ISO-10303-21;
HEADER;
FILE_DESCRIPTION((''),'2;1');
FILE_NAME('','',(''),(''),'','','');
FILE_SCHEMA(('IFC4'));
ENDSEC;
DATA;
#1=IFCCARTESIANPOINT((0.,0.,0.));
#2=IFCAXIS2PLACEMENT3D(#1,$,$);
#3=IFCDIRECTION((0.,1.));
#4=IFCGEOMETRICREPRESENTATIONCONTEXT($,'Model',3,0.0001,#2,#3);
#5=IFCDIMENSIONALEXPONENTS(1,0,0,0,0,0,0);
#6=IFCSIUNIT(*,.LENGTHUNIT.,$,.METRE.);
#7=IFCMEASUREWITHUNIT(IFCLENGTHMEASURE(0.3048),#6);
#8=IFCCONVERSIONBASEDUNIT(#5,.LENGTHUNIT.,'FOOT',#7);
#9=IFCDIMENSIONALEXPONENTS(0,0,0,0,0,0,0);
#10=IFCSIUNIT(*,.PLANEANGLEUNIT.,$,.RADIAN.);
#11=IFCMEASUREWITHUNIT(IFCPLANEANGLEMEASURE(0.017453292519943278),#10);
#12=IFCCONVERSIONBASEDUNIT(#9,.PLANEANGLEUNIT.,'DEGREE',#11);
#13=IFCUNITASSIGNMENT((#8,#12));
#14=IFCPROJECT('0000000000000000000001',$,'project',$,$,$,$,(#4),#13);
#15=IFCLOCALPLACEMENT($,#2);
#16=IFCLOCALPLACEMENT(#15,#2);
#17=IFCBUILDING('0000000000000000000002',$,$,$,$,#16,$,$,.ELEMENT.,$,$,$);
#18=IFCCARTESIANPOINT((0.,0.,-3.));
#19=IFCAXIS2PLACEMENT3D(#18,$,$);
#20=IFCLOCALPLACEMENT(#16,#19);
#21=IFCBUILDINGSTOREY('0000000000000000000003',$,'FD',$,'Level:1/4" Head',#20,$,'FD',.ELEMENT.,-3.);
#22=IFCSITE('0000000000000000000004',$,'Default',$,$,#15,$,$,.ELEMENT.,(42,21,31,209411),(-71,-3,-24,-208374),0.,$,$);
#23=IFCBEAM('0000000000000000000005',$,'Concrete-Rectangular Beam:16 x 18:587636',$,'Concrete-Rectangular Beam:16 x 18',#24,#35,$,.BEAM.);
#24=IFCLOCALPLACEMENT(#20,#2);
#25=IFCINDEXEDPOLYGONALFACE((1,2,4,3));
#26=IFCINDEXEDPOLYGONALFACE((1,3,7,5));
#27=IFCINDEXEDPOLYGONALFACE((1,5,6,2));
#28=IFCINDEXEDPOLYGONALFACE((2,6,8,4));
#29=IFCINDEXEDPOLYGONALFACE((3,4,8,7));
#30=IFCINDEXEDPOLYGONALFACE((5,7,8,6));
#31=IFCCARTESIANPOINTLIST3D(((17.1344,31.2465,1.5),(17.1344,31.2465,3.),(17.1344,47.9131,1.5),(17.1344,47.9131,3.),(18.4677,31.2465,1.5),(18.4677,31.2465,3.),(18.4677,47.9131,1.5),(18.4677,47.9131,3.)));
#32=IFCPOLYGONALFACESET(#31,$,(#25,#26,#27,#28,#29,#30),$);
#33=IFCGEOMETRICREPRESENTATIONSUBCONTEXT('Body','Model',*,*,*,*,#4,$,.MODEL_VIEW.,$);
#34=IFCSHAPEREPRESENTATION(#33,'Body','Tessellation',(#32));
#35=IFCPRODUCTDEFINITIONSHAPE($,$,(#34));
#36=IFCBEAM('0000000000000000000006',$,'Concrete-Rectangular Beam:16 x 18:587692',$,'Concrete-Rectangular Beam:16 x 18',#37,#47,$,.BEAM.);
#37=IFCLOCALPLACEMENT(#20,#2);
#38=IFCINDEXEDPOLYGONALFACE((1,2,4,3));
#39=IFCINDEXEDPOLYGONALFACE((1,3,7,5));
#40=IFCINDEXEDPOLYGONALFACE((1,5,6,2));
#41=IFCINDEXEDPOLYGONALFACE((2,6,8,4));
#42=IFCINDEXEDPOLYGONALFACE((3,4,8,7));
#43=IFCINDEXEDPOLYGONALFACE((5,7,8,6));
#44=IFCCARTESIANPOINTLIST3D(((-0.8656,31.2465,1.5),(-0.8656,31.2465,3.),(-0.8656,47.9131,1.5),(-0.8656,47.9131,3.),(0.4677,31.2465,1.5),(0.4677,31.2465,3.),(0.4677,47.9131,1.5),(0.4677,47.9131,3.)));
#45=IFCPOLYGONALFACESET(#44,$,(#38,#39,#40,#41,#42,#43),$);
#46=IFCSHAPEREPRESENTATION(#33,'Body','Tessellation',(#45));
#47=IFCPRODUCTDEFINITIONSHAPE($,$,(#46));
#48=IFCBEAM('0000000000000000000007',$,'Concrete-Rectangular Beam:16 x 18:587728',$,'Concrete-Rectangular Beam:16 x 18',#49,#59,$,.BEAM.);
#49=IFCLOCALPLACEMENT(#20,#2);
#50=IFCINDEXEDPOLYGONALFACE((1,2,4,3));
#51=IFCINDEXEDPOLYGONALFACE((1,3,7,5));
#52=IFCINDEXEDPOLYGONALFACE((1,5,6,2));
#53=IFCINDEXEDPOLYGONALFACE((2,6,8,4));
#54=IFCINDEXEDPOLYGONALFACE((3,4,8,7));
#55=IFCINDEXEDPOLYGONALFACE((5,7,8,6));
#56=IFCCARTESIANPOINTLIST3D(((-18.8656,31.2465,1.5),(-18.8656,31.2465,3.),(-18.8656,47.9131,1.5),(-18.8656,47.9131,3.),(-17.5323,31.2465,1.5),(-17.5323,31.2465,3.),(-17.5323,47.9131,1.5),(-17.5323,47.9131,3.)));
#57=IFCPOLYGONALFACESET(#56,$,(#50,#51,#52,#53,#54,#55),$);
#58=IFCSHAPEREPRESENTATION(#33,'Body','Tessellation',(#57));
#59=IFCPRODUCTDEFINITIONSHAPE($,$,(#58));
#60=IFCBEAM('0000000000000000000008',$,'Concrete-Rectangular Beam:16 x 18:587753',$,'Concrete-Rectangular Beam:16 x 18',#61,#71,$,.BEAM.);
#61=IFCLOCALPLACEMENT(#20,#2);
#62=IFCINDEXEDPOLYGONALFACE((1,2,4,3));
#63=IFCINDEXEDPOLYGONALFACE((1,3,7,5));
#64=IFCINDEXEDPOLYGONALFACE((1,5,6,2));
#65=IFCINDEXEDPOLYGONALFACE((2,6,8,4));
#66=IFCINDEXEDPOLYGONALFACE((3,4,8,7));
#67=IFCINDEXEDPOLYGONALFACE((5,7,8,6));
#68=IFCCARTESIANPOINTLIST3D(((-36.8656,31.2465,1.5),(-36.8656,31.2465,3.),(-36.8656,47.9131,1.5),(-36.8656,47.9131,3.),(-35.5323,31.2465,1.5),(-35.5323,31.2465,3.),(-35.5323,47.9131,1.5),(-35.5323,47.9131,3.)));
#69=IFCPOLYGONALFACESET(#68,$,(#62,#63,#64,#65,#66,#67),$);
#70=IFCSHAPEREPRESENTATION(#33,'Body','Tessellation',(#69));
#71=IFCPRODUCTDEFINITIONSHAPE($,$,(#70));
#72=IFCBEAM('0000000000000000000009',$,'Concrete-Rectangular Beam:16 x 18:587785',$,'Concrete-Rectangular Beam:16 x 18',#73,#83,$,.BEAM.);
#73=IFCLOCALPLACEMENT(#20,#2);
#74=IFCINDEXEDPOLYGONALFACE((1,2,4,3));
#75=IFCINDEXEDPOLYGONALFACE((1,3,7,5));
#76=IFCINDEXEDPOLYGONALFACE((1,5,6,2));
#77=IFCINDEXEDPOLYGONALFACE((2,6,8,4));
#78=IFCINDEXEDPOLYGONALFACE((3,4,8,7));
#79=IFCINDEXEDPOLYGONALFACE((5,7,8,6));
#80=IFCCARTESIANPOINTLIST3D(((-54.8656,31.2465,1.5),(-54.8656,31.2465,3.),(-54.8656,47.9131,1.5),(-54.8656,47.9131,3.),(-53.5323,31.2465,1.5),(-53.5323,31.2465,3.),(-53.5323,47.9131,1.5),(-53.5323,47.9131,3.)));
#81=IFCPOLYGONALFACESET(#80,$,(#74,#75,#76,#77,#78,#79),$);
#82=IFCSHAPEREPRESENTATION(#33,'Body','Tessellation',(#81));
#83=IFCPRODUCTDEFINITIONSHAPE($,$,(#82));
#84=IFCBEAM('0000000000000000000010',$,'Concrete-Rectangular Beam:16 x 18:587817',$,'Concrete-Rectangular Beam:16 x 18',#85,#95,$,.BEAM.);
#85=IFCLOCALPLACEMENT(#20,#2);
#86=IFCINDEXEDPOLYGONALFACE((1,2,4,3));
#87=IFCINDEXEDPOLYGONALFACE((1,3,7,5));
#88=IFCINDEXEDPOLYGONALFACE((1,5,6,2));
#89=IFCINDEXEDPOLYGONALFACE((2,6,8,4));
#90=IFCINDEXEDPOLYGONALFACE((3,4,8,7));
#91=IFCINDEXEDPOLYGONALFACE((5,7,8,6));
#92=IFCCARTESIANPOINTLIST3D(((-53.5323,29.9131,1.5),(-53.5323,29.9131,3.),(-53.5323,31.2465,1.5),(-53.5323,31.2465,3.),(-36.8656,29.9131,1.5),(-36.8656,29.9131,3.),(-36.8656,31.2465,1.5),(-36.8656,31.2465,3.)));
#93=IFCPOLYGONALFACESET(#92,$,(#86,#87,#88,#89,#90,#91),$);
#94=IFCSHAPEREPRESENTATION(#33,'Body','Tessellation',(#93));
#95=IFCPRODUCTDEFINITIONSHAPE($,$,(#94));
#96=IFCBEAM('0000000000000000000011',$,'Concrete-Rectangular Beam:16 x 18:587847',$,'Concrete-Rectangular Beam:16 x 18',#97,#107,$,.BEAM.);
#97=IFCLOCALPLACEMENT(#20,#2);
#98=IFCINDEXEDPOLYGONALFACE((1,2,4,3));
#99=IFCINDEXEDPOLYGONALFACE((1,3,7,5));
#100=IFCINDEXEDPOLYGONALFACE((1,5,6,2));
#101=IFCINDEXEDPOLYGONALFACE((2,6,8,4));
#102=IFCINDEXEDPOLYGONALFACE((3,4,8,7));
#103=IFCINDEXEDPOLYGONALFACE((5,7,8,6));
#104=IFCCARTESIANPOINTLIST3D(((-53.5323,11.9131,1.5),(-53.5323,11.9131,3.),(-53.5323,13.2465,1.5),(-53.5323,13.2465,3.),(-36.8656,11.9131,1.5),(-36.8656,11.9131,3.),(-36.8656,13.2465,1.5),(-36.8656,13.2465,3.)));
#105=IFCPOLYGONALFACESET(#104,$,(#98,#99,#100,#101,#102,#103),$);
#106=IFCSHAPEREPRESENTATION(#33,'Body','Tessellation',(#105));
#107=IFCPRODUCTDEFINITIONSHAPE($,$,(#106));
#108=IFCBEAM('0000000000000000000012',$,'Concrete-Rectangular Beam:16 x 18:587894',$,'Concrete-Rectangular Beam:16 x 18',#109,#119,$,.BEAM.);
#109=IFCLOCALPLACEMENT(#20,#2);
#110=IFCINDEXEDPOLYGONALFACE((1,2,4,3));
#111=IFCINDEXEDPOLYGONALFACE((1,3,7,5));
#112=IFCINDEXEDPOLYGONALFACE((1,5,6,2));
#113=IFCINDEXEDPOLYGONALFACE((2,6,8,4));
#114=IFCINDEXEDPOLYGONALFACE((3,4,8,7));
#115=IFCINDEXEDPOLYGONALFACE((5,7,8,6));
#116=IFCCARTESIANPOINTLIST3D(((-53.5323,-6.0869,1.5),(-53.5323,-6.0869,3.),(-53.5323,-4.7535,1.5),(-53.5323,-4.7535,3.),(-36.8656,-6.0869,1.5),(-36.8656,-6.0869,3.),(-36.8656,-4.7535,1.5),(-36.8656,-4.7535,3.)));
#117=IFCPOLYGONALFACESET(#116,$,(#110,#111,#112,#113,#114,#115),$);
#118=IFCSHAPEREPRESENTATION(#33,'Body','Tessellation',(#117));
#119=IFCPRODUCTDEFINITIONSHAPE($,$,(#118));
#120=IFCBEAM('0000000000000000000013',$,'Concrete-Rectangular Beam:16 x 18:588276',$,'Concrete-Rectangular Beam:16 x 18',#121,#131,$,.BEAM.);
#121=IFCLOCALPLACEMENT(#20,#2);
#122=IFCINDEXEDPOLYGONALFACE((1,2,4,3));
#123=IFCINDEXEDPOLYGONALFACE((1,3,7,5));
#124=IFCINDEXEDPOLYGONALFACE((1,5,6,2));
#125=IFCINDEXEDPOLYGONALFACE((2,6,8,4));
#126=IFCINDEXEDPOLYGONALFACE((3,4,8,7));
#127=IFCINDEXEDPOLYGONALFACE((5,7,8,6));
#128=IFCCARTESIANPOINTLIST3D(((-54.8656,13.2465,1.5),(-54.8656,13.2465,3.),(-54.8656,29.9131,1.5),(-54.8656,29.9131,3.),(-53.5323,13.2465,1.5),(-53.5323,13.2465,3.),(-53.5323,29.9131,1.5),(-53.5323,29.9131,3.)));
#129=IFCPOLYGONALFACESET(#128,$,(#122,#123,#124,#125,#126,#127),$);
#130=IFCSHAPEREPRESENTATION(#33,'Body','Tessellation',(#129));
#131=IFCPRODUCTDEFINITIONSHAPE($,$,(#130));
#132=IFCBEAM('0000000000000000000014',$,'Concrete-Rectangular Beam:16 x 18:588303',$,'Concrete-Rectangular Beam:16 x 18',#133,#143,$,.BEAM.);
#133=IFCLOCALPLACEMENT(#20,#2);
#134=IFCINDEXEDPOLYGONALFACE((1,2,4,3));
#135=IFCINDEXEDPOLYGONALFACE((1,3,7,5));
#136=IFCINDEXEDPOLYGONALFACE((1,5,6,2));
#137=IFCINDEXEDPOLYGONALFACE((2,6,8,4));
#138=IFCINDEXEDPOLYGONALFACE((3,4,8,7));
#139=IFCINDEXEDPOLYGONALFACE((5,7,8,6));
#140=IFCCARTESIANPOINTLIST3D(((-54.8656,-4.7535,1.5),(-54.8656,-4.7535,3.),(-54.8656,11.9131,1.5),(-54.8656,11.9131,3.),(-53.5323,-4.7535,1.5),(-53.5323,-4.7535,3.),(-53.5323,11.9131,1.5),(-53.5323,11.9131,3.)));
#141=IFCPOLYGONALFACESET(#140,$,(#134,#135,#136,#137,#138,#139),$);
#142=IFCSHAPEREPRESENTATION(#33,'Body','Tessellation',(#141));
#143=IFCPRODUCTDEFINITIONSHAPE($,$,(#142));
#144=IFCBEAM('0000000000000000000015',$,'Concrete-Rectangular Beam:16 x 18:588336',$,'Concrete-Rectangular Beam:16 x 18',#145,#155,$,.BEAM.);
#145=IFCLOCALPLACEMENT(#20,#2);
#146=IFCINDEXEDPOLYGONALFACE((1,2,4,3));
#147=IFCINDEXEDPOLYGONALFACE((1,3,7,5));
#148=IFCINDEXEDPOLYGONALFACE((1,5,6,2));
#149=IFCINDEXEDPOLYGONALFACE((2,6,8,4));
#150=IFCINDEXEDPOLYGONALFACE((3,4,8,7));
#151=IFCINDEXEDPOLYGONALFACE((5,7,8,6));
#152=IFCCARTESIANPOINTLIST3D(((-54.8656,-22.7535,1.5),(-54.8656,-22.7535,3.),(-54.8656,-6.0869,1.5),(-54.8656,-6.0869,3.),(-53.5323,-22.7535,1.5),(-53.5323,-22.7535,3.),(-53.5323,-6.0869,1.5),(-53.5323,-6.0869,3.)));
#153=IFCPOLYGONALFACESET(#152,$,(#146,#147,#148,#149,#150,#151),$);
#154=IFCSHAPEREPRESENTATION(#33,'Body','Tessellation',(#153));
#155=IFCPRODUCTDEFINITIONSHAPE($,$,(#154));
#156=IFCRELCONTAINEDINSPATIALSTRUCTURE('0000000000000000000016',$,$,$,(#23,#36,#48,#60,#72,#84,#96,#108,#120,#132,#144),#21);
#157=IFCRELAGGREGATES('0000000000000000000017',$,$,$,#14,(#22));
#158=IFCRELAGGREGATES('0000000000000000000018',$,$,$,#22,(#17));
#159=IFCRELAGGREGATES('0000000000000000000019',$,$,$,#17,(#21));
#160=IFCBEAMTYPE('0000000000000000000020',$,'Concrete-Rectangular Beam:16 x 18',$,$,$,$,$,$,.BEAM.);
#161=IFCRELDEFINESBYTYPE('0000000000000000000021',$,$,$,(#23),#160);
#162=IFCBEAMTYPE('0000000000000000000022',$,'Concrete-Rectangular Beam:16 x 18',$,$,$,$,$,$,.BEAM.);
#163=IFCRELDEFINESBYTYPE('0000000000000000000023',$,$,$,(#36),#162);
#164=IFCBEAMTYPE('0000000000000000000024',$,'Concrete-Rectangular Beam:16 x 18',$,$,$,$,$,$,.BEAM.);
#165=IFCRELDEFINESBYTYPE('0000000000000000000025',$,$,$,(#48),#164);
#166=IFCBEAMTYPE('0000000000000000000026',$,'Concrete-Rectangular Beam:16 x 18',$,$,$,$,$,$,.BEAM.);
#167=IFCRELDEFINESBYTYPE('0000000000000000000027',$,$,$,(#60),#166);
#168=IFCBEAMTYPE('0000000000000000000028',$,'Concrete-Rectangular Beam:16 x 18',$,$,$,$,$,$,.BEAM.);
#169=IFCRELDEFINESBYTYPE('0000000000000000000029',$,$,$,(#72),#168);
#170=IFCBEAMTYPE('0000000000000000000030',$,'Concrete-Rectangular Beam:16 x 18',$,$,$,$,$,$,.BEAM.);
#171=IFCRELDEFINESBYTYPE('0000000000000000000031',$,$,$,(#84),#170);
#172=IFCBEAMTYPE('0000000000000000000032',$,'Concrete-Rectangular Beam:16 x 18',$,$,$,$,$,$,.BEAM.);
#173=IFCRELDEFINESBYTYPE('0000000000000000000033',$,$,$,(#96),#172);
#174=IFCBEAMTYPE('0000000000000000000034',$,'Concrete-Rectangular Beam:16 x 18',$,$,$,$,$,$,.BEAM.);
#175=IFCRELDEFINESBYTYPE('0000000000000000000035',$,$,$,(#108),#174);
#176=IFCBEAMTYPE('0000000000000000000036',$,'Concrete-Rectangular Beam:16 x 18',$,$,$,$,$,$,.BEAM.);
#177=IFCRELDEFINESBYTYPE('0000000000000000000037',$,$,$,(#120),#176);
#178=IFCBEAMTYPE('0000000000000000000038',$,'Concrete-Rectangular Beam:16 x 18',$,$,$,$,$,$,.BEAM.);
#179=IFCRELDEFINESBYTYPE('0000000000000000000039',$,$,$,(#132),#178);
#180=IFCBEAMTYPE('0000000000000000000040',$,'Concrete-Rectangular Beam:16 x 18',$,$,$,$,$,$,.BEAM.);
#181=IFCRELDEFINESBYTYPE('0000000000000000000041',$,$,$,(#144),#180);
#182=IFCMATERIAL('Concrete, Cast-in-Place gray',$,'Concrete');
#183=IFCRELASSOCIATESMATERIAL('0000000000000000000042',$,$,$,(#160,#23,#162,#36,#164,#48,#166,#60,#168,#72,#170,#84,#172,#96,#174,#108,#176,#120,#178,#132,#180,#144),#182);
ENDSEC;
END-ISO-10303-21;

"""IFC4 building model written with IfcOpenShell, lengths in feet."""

from ifc_helpers import new_model, entity, si_unit, converted_unit, direction, frame, origin, place, context, subcontext, project, spatial, indexed_curve, outline, extrude, source, transform, mapped, material, type_object, type_shapes, element, save


model = new_model("IFC4")

# Units and contexts
model_context = context("Model", 3, precision=0.0001, world=origin(), true_north=direction((0.0, 1.0)))
body_context = subcontext(model_context, "Body", "Model", "MODEL_VIEW")
ifc_project = project(units=[converted_unit("LENGTHUNIT", "FOOT", entity("IfcLengthMeasure", 0.3048), si_unit("LENGTHUNIT", "METRE"), dimensions=[1, 0, 0, 0, 0, 0, 0]), converted_unit("PLANEANGLEUNIT", "DEGREE", entity("IfcPlaneAngleMeasure", 0.017453292519943278), si_unit("PLANEANGLEUNIT", "RADIAN"), dimensions=[0, 0, 0, 0, 0, 0, 0])], contexts=[model_context])

# Site, building, storey
site_placement = place(None, origin())
site = spatial("IfcSite", under=ifc_project, at=site_placement, Name="Default", CompositionType="ELEMENT", RefLatitude=(42, 21, 31, 209411), RefLongitude=(-71, -3, -24, -208374), RefElevation=0.0)
building_placement = place(site_placement, origin())
building = spatial("IfcBuilding", under=site, at=building_placement, CompositionType="ELEMENT")
storey_placement = place(building_placement, frame((0.0, 0.0, -3.0)))
storey = spatial("IfcBuildingStorey", under=building, at=storey_placement, Name="FD", ObjectType="Level:1/4\" Head", LongName="FD", CompositionType="ELEMENT", Elevation=-3.0)

# Shared definitions
ifc_material = material(Name="Concrete, Cast-in-Place gray", Category="Concrete")

# Beams
beam_type_1 = type_object("IfcBeamType", Name="Concrete-Rectangular Beam:16 x 18", PredefinedType="BEAM", material=ifc_material)
shared_shape_1 = source(origin(), body_context, "Body", "SweptSolid", [
    extrude(outline(indexed_curve([(-0.6667, -0.75), (0.6667, -0.75), (0.6667, 0.75), (-0.6667, 0.75), (-0.6667, -0.75)], self_intersect=False)), frame((17.801, 47.9131, -0.75), z_axis=(0.0, -1.0, 0.0), x_axis=(-1.0, 0.0, 0.0)), (0.0, 0.0, 1.0), 16.6667),
])
type_shapes(beam_type_1, [shared_shape_1])
beam_1_placement = place(storey_placement, frame((0.0, 0.0, 3.0)))
element("IfcBeam", 1, at=beam_1_placement, inside=storey, type_object=beam_type_1, material=ifc_material, Name="Concrete-Rectangular Beam:16 x 18:587636", ObjectType="Concrete-Rectangular Beam:16 x 18", PredefinedType="BEAM", context=body_context, shape_type="MappedRepresentation", body=[
    mapped(shared_shape_1, transform((0.0, 0.0, 0.0), scale=1.0)),
])
beam_type_2 = type_object("IfcBeamType", Name="Concrete-Rectangular Beam:16 x 18", PredefinedType="BEAM", material=ifc_material)
shared_shape_2 = source(origin(), body_context, "Body", "SweptSolid", [
    extrude(outline(indexed_curve([(-0.6667, -0.75), (0.6667, -0.75), (0.6667, 0.75), (-0.6667, 0.75), (-0.6667, -0.75)], self_intersect=False)), frame((-0.199, 47.9131, -0.75), z_axis=(0.0, -1.0, 0.0), x_axis=(-1.0, 0.0, 0.0)), (0.0, 0.0, 1.0), 16.6667),
])
type_shapes(beam_type_2, [shared_shape_2])
beam_2_placement = place(storey_placement, frame((0.0, 0.0, 3.0)))
element("IfcBeam", 2, at=beam_2_placement, inside=storey, type_object=beam_type_2, material=ifc_material, Name="Concrete-Rectangular Beam:16 x 18:587692", ObjectType="Concrete-Rectangular Beam:16 x 18", PredefinedType="BEAM", context=body_context, shape_type="MappedRepresentation", body=[
    mapped(shared_shape_2, transform((0.0, 0.0, 0.0), scale=1.0)),
])
beam_type_3 = type_object("IfcBeamType", Name="Concrete-Rectangular Beam:16 x 18", PredefinedType="BEAM", material=ifc_material)
shared_shape_3 = source(origin(), body_context, "Body", "SweptSolid", [
    extrude(outline(indexed_curve([(-0.6667, -0.75), (0.6667, -0.75), (0.6667, 0.75), (-0.6667, 0.75), (-0.6667, -0.75)], self_intersect=False)), frame((-18.199, 47.9131, -0.75), z_axis=(0.0, -1.0, 0.0), x_axis=(-1.0, 0.0, 0.0)), (0.0, 0.0, 1.0), 16.6667),
])
type_shapes(beam_type_3, [shared_shape_3])
beam_3_placement = place(storey_placement, frame((0.0, 0.0, 3.0)))
element("IfcBeam", 3, at=beam_3_placement, inside=storey, type_object=beam_type_3, material=ifc_material, Name="Concrete-Rectangular Beam:16 x 18:587728", ObjectType="Concrete-Rectangular Beam:16 x 18", PredefinedType="BEAM", context=body_context, shape_type="MappedRepresentation", body=[
    mapped(shared_shape_3, transform((0.0, 0.0, 0.0), scale=1.0)),
])
beam_type_4 = type_object("IfcBeamType", Name="Concrete-Rectangular Beam:16 x 18", PredefinedType="BEAM", material=ifc_material)
shared_shape_4 = source(origin(), body_context, "Body", "SweptSolid", [
    extrude(outline(indexed_curve([(-0.6667, -0.75), (0.6667, -0.75), (0.6667, 0.75), (-0.6667, 0.75), (-0.6667, -0.75)], self_intersect=False)), frame((-36.199, 47.9131, -0.75), z_axis=(0.0, -1.0, 0.0), x_axis=(-1.0, 0.0, 0.0)), (0.0, 0.0, 1.0), 16.6667),
])
type_shapes(beam_type_4, [shared_shape_4])
beam_4_placement = place(storey_placement, frame((0.0, 0.0, 3.0)))
element("IfcBeam", 4, at=beam_4_placement, inside=storey, type_object=beam_type_4, material=ifc_material, Name="Concrete-Rectangular Beam:16 x 18:587753", ObjectType="Concrete-Rectangular Beam:16 x 18", PredefinedType="BEAM", context=body_context, shape_type="MappedRepresentation", body=[
    mapped(shared_shape_4, transform((0.0, 0.0, 0.0), scale=1.0)),
])
beam_type_5 = type_object("IfcBeamType", Name="Concrete-Rectangular Beam:16 x 18", PredefinedType="BEAM", material=ifc_material)
shared_shape_5 = source(origin(), body_context, "Body", "SweptSolid", [
    extrude(outline(indexed_curve([(-0.6667, -0.75), (0.6667, -0.75), (0.6667, 0.75), (-0.6667, 0.75), (-0.6667, -0.75)], self_intersect=False)), frame((-54.199, 31.2465, -0.75), z_axis=(0.0, 1.0, 0.0), x_axis=(-1.0, 0.0, 0.0)), (0.0, 0.0, 1.0), 16.6667),
])
type_shapes(beam_type_5, [shared_shape_5])
beam_5_placement = place(storey_placement, frame((0.0, 0.0, 3.0)))
element("IfcBeam", 5, at=beam_5_placement, inside=storey, type_object=beam_type_5, material=ifc_material, Name="Concrete-Rectangular Beam:16 x 18:587785", ObjectType="Concrete-Rectangular Beam:16 x 18", PredefinedType="BEAM", context=body_context, shape_type="MappedRepresentation", body=[
    mapped(shared_shape_5, transform((0.0, 0.0, 0.0), scale=1.0)),
])
beam_type_6 = type_object("IfcBeamType", Name="Concrete-Rectangular Beam:16 x 18", PredefinedType="BEAM", material=ifc_material)
shared_shape_6 = source(origin(), body_context, "Body", "SweptSolid", [
    extrude(outline(indexed_curve([(-0.75, -0.6667), (0.75, -0.6667), (0.75, 0.6667), (-0.75, 0.6667), (-0.75, -0.6667)], self_intersect=False)), frame((-53.5323, 30.5798, -0.75), z_axis=(1.0, 0.0, 0.0), x_axis=(0.0, 0.0, -1.0)), (0.0, 0.0, 1.0), 16.6667),
])
type_shapes(beam_type_6, [shared_shape_6])
beam_6_placement = place(storey_placement, frame((0.0, 0.0, 3.0)))
element("IfcBeam", 6, at=beam_6_placement, inside=storey, type_object=beam_type_6, material=ifc_material, Name="Concrete-Rectangular Beam:16 x 18:587817", ObjectType="Concrete-Rectangular Beam:16 x 18", PredefinedType="BEAM", context=body_context, shape_type="MappedRepresentation", body=[
    mapped(shared_shape_6, transform((0.0, 0.0, 0.0), scale=1.0)),
])
beam_type_7 = type_object("IfcBeamType", Name="Concrete-Rectangular Beam:16 x 18", PredefinedType="BEAM", material=ifc_material)
shared_shape_7 = source(origin(), body_context, "Body", "SweptSolid", [
    extrude(outline(indexed_curve([(-0.75, -0.6667), (0.75, -0.6667), (0.75, 0.6667), (-0.75, 0.6667), (-0.75, -0.6667)], self_intersect=False)), frame((-53.5323, 12.5798, -0.75), z_axis=(1.0, 0.0, 0.0), x_axis=(0.0, 0.0, -1.0)), (0.0, 0.0, 1.0), 16.6667),
])
type_shapes(beam_type_7, [shared_shape_7])
beam_7_placement = place(storey_placement, frame((0.0, 0.0, 3.0)))
element("IfcBeam", 7, at=beam_7_placement, inside=storey, type_object=beam_type_7, material=ifc_material, Name="Concrete-Rectangular Beam:16 x 18:587847", ObjectType="Concrete-Rectangular Beam:16 x 18", PredefinedType="BEAM", context=body_context, shape_type="MappedRepresentation", body=[
    mapped(shared_shape_7, transform((0.0, 0.0, 0.0), scale=1.0)),
])
beam_type_8 = type_object("IfcBeamType", Name="Concrete-Rectangular Beam:16 x 18", PredefinedType="BEAM", material=ifc_material)
shared_shape_8 = source(origin(), body_context, "Body", "SweptSolid", [
    extrude(outline(indexed_curve([(-0.75, -0.6667), (0.75, -0.6667), (0.75, 0.6667), (-0.75, 0.6667), (-0.75, -0.6667)], self_intersect=False)), frame((-53.5323, -5.4202, -0.75), z_axis=(1.0, 0.0, 0.0), x_axis=(0.0, 0.0, -1.0)), (0.0, 0.0, 1.0), 16.6667),
])
type_shapes(beam_type_8, [shared_shape_8])
beam_8_placement = place(storey_placement, frame((0.0, 0.0, 3.0)))
element("IfcBeam", 8, at=beam_8_placement, inside=storey, type_object=beam_type_8, material=ifc_material, Name="Concrete-Rectangular Beam:16 x 18:587894", ObjectType="Concrete-Rectangular Beam:16 x 18", PredefinedType="BEAM", context=body_context, shape_type="MappedRepresentation", body=[
    mapped(shared_shape_8, transform((0.0, 0.0, 0.0), scale=1.0)),
])
beam_type_9 = type_object("IfcBeamType", Name="Concrete-Rectangular Beam:16 x 18", PredefinedType="BEAM", material=ifc_material)
shared_shape_9 = source(origin(), body_context, "Body", "SweptSolid", [
    extrude(outline(indexed_curve([(-0.6667, -0.75), (0.6667, -0.75), (0.6667, 0.75), (-0.6667, 0.75), (-0.6667, -0.75)], self_intersect=False)), frame((-54.199, 29.9131, -0.75), z_axis=(0.0, -1.0, 0.0), x_axis=(-1.0, 0.0, 0.0)), (0.0, 0.0, 1.0), 16.6667),
])
type_shapes(beam_type_9, [shared_shape_9])
beam_9_placement = place(storey_placement, frame((0.0, 0.0, 3.0)))
element("IfcBeam", 9, at=beam_9_placement, inside=storey, type_object=beam_type_9, material=ifc_material, Name="Concrete-Rectangular Beam:16 x 18:588276", ObjectType="Concrete-Rectangular Beam:16 x 18", PredefinedType="BEAM", context=body_context, shape_type="MappedRepresentation", body=[
    mapped(shared_shape_9, transform((0.0, 0.0, 0.0), scale=1.0)),
])
beam_type_10 = type_object("IfcBeamType", Name="Concrete-Rectangular Beam:16 x 18", PredefinedType="BEAM", material=ifc_material)
shared_shape_10 = source(origin(), body_context, "Body", "SweptSolid", [
    extrude(outline(indexed_curve([(-0.6667, -0.75), (0.6667, -0.75), (0.6667, 0.75), (-0.6667, 0.75), (-0.6667, -0.75)], self_intersect=False)), frame((-54.199, 11.9131, -0.75), z_axis=(0.0, -1.0, 0.0), x_axis=(-1.0, 0.0, 0.0)), (0.0, 0.0, 1.0), 16.6667),
])
type_shapes(beam_type_10, [shared_shape_10])
beam_10_placement = place(storey_placement, frame((0.0, 0.0, 3.0)))
element("IfcBeam", 10, at=beam_10_placement, inside=storey, type_object=beam_type_10, material=ifc_material, Name="Concrete-Rectangular Beam:16 x 18:588303", ObjectType="Concrete-Rectangular Beam:16 x 18", PredefinedType="BEAM", context=body_context, shape_type="MappedRepresentation", body=[
    mapped(shared_shape_10, transform((0.0, 0.0, 0.0), scale=1.0)),
])
beam_type_11 = type_object("IfcBeamType", Name="Concrete-Rectangular Beam:16 x 18", PredefinedType="BEAM", material=ifc_material)
shared_shape_11 = source(origin(), body_context, "Body", "SweptSolid", [
    extrude(outline(indexed_curve([(-0.6667, -0.75), (0.6667, -0.75), (0.6667, 0.75), (-0.6667, 0.75), (-0.6667, -0.75)], self_intersect=False)), frame((-54.199, -6.0869, -0.75), z_axis=(0.0, -1.0, 0.0), x_axis=(-1.0, 0.0, 0.0)), (0.0, 0.0, 1.0), 16.6667),
])
type_shapes(beam_type_11, [shared_shape_11])
beam_11_placement = place(storey_placement, frame((0.0, 0.0, 3.0)))
element("IfcBeam", 11, at=beam_11_placement, inside=storey, type_object=beam_type_11, material=ifc_material, Name="Concrete-Rectangular Beam:16 x 18:588336", ObjectType="Concrete-Rectangular Beam:16 x 18", PredefinedType="BEAM", context=body_context, shape_type="MappedRepresentation", body=[
    mapped(shared_shape_11, transform((0.0, 0.0, 0.0), scale=1.0)),
])

save(model, "model.ifc")
